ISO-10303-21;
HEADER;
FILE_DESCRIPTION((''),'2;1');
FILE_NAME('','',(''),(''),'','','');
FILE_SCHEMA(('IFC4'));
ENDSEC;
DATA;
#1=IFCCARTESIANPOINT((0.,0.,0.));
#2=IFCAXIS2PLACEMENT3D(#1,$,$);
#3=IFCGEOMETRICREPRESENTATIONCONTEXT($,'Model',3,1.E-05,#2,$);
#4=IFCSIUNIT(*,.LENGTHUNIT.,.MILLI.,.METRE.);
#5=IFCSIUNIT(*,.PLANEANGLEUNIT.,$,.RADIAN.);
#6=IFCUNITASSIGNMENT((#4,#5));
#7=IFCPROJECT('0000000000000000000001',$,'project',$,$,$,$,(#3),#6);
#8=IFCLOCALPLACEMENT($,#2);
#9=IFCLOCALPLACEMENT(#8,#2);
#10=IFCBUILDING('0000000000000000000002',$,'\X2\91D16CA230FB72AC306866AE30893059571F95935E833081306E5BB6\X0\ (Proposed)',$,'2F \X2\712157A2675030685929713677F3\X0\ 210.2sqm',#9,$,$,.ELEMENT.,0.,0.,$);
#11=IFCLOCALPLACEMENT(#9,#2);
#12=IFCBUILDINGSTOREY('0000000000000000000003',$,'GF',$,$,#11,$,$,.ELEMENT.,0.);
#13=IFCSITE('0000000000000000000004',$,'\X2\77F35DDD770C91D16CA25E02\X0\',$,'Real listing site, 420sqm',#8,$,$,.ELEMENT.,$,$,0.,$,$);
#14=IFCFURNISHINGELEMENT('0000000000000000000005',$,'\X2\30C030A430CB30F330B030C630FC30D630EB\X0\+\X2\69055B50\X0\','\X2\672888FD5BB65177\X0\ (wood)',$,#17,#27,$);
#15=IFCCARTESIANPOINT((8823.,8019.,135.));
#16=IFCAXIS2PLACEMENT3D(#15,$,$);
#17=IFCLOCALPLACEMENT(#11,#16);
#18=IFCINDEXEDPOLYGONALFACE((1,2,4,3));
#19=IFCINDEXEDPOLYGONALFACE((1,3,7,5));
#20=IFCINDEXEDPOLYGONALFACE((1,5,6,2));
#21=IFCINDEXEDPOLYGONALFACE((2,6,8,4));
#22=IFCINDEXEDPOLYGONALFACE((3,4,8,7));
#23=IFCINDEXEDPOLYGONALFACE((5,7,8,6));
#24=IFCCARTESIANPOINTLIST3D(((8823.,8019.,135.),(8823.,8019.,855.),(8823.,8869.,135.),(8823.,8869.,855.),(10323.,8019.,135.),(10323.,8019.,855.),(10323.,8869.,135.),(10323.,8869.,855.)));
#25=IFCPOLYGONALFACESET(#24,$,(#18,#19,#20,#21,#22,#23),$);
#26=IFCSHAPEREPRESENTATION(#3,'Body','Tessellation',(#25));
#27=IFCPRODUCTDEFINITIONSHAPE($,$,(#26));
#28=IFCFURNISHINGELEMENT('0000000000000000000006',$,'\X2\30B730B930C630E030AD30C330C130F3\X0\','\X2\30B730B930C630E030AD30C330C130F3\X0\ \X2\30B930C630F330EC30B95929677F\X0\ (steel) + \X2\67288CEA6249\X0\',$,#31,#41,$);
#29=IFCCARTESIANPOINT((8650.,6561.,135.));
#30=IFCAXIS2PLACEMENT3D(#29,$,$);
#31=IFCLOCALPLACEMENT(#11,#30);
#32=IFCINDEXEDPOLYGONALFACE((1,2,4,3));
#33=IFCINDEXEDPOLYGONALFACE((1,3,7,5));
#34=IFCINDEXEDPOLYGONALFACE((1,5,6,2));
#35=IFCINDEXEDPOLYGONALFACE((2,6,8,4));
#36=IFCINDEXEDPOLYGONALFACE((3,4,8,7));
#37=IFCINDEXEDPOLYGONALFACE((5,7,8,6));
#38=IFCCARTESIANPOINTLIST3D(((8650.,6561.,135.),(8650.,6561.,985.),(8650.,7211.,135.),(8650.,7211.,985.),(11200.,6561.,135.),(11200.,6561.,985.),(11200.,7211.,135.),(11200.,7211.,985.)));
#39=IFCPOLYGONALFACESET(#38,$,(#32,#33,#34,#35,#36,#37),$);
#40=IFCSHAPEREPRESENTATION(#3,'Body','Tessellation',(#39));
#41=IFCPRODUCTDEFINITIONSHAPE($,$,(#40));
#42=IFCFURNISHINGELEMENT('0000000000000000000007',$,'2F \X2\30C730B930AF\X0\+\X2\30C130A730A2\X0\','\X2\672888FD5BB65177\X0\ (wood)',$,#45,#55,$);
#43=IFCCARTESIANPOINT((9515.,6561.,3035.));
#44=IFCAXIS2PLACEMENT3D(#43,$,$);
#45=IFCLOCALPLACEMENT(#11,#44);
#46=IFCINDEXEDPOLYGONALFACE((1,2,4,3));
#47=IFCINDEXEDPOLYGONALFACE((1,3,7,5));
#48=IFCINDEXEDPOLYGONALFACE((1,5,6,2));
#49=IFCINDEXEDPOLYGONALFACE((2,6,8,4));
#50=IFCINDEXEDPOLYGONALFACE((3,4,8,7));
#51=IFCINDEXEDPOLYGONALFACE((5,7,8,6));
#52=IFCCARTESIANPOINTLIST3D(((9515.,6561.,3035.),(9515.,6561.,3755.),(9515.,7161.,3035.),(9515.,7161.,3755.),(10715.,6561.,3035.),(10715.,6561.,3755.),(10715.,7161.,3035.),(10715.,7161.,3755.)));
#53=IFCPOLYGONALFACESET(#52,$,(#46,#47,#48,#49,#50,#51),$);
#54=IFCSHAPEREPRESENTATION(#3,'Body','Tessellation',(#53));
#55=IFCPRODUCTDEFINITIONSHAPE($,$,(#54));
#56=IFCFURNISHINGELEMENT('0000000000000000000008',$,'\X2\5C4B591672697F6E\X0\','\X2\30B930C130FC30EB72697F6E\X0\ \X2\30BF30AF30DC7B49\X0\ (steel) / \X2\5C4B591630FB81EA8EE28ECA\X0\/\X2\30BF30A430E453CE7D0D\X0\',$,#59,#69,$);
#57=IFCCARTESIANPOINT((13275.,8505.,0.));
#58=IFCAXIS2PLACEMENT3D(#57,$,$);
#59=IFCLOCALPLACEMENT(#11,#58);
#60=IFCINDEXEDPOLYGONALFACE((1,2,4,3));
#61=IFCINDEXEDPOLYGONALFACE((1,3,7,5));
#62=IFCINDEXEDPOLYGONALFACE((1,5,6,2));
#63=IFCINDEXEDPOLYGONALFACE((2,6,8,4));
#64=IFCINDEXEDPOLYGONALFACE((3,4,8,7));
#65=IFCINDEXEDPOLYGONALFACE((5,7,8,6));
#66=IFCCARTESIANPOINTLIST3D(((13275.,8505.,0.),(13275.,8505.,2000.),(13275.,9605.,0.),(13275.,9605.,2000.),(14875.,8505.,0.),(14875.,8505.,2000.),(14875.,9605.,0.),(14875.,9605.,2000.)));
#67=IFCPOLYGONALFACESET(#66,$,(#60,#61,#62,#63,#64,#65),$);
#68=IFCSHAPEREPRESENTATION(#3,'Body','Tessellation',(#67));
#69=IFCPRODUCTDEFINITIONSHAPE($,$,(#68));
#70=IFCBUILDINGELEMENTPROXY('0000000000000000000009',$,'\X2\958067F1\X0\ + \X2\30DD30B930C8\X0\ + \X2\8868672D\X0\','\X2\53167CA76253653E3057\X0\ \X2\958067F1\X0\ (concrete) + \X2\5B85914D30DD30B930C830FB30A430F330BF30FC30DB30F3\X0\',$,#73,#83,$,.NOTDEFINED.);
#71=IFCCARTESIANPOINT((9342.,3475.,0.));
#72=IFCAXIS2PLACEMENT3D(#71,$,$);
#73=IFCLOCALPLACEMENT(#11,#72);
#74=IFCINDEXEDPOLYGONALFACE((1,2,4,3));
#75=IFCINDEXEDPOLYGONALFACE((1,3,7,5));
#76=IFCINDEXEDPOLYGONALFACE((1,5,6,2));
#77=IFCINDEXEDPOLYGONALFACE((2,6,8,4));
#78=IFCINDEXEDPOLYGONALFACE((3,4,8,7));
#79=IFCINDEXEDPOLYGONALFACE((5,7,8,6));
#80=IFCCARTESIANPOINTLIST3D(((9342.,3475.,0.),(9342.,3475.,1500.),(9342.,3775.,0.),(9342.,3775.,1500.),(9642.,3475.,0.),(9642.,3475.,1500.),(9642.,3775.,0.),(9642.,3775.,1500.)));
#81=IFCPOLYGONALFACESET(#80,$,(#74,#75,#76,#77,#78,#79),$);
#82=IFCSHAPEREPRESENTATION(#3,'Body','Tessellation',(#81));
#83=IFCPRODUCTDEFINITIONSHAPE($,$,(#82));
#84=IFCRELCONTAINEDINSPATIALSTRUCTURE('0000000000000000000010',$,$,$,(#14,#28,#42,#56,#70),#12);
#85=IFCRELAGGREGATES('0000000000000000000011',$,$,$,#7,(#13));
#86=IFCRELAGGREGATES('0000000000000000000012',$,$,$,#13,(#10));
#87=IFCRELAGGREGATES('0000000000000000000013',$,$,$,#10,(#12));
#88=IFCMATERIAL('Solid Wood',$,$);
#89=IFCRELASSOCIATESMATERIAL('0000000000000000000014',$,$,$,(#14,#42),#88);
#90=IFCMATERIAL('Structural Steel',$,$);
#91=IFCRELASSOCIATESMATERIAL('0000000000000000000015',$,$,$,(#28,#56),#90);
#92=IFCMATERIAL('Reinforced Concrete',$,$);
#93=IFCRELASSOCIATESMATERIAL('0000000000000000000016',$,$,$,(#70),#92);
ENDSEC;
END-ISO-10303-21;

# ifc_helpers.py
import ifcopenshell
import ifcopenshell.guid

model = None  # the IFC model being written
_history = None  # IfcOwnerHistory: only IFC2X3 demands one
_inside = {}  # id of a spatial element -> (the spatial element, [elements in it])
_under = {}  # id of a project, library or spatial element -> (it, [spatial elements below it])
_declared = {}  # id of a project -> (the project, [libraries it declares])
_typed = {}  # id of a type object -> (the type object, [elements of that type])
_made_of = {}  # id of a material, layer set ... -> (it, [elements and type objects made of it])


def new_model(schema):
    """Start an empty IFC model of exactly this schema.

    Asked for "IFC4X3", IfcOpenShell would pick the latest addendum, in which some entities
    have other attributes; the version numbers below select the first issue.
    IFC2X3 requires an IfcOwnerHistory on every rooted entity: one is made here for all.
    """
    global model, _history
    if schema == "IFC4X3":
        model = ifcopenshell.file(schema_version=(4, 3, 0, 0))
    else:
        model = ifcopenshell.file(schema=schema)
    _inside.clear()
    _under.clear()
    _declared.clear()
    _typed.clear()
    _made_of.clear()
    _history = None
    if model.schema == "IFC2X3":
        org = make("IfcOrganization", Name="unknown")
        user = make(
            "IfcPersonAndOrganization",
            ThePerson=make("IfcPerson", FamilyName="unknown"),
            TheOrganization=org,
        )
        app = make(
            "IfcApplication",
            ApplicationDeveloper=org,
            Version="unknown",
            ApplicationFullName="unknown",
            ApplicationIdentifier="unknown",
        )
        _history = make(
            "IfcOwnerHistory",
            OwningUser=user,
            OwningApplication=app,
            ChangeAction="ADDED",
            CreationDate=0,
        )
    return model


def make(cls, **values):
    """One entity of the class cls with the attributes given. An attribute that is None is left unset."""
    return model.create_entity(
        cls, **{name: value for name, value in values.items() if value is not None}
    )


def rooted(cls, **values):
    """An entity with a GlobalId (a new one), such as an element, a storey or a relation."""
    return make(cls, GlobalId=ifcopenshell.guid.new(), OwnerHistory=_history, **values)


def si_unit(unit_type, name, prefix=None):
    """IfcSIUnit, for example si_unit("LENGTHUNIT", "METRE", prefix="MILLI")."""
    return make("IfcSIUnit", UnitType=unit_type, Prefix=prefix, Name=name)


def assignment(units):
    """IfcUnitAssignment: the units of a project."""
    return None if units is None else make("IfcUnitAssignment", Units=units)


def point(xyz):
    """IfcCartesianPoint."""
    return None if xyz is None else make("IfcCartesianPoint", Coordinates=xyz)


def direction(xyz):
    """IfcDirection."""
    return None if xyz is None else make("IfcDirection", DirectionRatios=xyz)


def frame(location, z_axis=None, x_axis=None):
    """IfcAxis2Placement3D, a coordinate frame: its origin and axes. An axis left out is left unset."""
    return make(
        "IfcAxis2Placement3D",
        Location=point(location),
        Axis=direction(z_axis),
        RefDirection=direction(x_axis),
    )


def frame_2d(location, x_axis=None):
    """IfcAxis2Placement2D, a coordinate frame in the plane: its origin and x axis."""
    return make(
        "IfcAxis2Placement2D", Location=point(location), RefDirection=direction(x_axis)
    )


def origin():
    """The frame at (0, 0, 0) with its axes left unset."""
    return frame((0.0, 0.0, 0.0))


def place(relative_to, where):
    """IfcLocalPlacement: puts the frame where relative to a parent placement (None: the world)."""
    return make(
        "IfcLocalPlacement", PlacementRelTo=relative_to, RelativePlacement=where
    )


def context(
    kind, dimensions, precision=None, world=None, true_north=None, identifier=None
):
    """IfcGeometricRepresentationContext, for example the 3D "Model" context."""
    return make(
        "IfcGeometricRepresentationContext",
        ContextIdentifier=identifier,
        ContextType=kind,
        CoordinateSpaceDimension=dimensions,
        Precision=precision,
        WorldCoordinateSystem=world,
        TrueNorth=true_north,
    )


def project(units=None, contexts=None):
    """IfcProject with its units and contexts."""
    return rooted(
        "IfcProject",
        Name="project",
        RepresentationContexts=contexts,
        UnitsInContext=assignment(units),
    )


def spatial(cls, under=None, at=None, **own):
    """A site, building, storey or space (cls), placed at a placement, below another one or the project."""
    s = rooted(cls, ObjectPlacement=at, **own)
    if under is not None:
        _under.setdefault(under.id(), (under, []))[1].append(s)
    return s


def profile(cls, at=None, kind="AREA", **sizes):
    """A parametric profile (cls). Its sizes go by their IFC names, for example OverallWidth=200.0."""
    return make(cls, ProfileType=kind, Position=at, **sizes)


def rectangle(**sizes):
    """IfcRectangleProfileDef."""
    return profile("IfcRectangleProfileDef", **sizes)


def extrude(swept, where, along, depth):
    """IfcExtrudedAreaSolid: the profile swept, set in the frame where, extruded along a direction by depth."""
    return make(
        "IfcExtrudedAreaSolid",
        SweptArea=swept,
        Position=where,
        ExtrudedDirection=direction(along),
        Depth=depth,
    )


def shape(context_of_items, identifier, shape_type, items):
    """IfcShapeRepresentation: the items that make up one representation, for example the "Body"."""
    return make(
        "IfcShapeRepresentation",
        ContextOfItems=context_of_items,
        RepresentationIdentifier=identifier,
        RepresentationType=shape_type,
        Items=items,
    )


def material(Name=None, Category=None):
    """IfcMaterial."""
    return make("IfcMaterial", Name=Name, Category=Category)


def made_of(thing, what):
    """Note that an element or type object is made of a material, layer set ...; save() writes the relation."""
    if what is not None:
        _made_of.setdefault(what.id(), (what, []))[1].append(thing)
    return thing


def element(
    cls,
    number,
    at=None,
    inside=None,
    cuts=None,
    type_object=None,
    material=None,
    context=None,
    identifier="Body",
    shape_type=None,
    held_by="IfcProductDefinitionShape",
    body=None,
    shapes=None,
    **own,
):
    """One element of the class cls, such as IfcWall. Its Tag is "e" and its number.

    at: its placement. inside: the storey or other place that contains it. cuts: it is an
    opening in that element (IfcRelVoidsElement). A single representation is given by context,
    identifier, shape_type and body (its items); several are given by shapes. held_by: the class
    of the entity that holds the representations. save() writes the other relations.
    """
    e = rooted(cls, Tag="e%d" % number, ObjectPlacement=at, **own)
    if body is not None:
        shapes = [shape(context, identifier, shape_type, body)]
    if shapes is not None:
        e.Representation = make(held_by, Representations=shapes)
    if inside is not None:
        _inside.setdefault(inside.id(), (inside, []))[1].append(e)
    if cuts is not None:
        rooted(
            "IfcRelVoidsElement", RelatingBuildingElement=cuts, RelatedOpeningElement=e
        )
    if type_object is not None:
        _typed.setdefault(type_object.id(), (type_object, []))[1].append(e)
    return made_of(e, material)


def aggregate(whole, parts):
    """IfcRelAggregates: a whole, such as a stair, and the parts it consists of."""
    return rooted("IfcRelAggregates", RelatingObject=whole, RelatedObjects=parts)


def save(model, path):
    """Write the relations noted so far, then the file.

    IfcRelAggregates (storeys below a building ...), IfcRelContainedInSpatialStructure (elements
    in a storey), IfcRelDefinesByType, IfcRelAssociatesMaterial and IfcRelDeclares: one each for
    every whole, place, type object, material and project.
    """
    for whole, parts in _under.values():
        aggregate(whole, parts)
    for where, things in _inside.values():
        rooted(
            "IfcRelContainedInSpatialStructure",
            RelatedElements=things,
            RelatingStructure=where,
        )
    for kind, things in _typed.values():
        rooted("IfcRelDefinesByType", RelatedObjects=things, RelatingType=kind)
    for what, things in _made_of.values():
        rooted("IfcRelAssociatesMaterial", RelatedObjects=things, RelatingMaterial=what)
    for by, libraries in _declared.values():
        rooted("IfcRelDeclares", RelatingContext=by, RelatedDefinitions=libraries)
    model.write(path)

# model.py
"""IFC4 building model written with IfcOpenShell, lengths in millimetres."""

from ifc_helpers import new_model, si_unit, frame, frame_2d, origin, place, context, project, spatial, rectangle, extrude, material, element, save


model = new_model("IFC4")

# Units and contexts
model_context = context("Model", 3, precision=1e-05, world=origin())
ifc_project = project(units=[si_unit("LENGTHUNIT", "METRE", prefix="MILLI"), si_unit("PLANEANGLEUNIT", "RADIAN")], contexts=[model_context])

# Site, building, storey
site_placement = place(None, origin())
site = spatial("IfcSite", under=ifc_project, at=site_placement, Name="石川県金沢市", ObjectType="Real listing site, 420sqm", CompositionType="ELEMENT", RefElevation=0.0)
building_placement = place(site_placement, origin())
building = spatial("IfcBuilding", under=site, at=building_placement, Name="金沢・犬と暮らす土間広めの家 (Proposed)", ObjectType="2F 無垢材と天然石 210.2sqm", CompositionType="ELEMENT", ElevationOfRefHeight=0.0, ElevationOfTerrain=0.0)
storey_placement = place(building_placement, origin())
storey = spatial("IfcBuildingStorey", under=building, at=storey_placement, Name="GF", CompositionType="ELEMENT", Elevation=0.0)

# Shared definitions
ifc_material_1 = material(Name="Solid Wood")

# Shared definitions
ifc_material_2 = material(Name="Reinforced Concrete")

# Shared definitions
ifc_material_3 = material(Name="Structural Steel")

# Furnishing elements
furnishing_1_placement = place(storey_placement, frame((8823.0, 8019.0, 135.0)))
element("IfcFurnishingElement", 1, at=furnishing_1_placement, inside=storey, material=ifc_material_1, Name="ダイニングテーブル+椅子", Description="木製家具 (wood)", context=model_context, shape_type="SweptSolid", body=[
    extrude(rectangle(XDim=1500.0, YDim=850.0, at=frame_2d((750.0, 425.0))), frame((8823.0, 8019.0, 135.0)), (0.0, 0.0, 1.0), 720.0),
])
furnishing_2_placement = place(storey_placement, frame((8650.0, 6561.0, 135.0)))
element("IfcFurnishingElement", 2, at=furnishing_2_placement, inside=storey, material=ifc_material_3, Name="システムキッチン", Description="システムキッチン ステンレス天板 (steel) + 木質扉", context=model_context, shape_type="SweptSolid", body=[
    extrude(rectangle(XDim=2550.0, YDim=650.0, at=frame_2d((1275.0, 325.0))), frame((8650.0, 6561.0, 135.0)), (0.0, 0.0, 1.0), 850.0),
])
furnishing_3_placement = place(storey_placement, frame((9515.0, 6561.0, 3035.0)))
element("IfcFurnishingElement", 3, at=furnishing_3_placement, inside=storey, material=ifc_material_1, Name="2F デスク+チェア", Description="木製家具 (wood)", context=model_context, shape_type="SweptSolid", body=[
    extrude(rectangle(XDim=1200.0, YDim=600.0, at=frame_2d((600.0, 300.0))), frame((9515.0, 6561.0, 3035.0)), (0.0, 0.0, 1.0), 720.0),
])
furnishing_4_placement = place(storey_placement, frame((13275.0, 8505.0, 0.0)))
element("IfcFurnishingElement", 4, at=furnishing_4_placement, inside=storey, material=ifc_material_3, Name="屋外物置", Description="スチール物置 タクボ等 (steel) / 屋外・自転車/タイヤ収納", context=model_context, shape_type="SweptSolid", body=[
    extrude(rectangle(XDim=1600.0, YDim=1100.0, at=frame_2d((800.0, 550.0))), frame((13275.0, 8505.0, 0.0)), (0.0, 0.0, 1.0), 2000.0),
])

# Building element proxy
proxy_placement = place(storey_placement, frame((9342.0, 3475.0, 0.0)))
element("IfcBuildingElementProxy", 5, at=proxy_placement, inside=storey, material=ifc_material_2, Name="門柱 + ポスト + 表札", Description="化粧打放し 門柱 (concrete) + 宅配ポスト・インターホン", PredefinedType="NOTDEFINED", context=model_context, shape_type="SweptSolid", body=[
    extrude(rectangle(XDim=300.0, YDim=300.0, at=frame_2d((150.0, 150.0))), frame((9342.0, 3475.0, 0.0)), (0.0, 0.0, 1.0), 1500.0),
])

save(model, "model.ifc")
